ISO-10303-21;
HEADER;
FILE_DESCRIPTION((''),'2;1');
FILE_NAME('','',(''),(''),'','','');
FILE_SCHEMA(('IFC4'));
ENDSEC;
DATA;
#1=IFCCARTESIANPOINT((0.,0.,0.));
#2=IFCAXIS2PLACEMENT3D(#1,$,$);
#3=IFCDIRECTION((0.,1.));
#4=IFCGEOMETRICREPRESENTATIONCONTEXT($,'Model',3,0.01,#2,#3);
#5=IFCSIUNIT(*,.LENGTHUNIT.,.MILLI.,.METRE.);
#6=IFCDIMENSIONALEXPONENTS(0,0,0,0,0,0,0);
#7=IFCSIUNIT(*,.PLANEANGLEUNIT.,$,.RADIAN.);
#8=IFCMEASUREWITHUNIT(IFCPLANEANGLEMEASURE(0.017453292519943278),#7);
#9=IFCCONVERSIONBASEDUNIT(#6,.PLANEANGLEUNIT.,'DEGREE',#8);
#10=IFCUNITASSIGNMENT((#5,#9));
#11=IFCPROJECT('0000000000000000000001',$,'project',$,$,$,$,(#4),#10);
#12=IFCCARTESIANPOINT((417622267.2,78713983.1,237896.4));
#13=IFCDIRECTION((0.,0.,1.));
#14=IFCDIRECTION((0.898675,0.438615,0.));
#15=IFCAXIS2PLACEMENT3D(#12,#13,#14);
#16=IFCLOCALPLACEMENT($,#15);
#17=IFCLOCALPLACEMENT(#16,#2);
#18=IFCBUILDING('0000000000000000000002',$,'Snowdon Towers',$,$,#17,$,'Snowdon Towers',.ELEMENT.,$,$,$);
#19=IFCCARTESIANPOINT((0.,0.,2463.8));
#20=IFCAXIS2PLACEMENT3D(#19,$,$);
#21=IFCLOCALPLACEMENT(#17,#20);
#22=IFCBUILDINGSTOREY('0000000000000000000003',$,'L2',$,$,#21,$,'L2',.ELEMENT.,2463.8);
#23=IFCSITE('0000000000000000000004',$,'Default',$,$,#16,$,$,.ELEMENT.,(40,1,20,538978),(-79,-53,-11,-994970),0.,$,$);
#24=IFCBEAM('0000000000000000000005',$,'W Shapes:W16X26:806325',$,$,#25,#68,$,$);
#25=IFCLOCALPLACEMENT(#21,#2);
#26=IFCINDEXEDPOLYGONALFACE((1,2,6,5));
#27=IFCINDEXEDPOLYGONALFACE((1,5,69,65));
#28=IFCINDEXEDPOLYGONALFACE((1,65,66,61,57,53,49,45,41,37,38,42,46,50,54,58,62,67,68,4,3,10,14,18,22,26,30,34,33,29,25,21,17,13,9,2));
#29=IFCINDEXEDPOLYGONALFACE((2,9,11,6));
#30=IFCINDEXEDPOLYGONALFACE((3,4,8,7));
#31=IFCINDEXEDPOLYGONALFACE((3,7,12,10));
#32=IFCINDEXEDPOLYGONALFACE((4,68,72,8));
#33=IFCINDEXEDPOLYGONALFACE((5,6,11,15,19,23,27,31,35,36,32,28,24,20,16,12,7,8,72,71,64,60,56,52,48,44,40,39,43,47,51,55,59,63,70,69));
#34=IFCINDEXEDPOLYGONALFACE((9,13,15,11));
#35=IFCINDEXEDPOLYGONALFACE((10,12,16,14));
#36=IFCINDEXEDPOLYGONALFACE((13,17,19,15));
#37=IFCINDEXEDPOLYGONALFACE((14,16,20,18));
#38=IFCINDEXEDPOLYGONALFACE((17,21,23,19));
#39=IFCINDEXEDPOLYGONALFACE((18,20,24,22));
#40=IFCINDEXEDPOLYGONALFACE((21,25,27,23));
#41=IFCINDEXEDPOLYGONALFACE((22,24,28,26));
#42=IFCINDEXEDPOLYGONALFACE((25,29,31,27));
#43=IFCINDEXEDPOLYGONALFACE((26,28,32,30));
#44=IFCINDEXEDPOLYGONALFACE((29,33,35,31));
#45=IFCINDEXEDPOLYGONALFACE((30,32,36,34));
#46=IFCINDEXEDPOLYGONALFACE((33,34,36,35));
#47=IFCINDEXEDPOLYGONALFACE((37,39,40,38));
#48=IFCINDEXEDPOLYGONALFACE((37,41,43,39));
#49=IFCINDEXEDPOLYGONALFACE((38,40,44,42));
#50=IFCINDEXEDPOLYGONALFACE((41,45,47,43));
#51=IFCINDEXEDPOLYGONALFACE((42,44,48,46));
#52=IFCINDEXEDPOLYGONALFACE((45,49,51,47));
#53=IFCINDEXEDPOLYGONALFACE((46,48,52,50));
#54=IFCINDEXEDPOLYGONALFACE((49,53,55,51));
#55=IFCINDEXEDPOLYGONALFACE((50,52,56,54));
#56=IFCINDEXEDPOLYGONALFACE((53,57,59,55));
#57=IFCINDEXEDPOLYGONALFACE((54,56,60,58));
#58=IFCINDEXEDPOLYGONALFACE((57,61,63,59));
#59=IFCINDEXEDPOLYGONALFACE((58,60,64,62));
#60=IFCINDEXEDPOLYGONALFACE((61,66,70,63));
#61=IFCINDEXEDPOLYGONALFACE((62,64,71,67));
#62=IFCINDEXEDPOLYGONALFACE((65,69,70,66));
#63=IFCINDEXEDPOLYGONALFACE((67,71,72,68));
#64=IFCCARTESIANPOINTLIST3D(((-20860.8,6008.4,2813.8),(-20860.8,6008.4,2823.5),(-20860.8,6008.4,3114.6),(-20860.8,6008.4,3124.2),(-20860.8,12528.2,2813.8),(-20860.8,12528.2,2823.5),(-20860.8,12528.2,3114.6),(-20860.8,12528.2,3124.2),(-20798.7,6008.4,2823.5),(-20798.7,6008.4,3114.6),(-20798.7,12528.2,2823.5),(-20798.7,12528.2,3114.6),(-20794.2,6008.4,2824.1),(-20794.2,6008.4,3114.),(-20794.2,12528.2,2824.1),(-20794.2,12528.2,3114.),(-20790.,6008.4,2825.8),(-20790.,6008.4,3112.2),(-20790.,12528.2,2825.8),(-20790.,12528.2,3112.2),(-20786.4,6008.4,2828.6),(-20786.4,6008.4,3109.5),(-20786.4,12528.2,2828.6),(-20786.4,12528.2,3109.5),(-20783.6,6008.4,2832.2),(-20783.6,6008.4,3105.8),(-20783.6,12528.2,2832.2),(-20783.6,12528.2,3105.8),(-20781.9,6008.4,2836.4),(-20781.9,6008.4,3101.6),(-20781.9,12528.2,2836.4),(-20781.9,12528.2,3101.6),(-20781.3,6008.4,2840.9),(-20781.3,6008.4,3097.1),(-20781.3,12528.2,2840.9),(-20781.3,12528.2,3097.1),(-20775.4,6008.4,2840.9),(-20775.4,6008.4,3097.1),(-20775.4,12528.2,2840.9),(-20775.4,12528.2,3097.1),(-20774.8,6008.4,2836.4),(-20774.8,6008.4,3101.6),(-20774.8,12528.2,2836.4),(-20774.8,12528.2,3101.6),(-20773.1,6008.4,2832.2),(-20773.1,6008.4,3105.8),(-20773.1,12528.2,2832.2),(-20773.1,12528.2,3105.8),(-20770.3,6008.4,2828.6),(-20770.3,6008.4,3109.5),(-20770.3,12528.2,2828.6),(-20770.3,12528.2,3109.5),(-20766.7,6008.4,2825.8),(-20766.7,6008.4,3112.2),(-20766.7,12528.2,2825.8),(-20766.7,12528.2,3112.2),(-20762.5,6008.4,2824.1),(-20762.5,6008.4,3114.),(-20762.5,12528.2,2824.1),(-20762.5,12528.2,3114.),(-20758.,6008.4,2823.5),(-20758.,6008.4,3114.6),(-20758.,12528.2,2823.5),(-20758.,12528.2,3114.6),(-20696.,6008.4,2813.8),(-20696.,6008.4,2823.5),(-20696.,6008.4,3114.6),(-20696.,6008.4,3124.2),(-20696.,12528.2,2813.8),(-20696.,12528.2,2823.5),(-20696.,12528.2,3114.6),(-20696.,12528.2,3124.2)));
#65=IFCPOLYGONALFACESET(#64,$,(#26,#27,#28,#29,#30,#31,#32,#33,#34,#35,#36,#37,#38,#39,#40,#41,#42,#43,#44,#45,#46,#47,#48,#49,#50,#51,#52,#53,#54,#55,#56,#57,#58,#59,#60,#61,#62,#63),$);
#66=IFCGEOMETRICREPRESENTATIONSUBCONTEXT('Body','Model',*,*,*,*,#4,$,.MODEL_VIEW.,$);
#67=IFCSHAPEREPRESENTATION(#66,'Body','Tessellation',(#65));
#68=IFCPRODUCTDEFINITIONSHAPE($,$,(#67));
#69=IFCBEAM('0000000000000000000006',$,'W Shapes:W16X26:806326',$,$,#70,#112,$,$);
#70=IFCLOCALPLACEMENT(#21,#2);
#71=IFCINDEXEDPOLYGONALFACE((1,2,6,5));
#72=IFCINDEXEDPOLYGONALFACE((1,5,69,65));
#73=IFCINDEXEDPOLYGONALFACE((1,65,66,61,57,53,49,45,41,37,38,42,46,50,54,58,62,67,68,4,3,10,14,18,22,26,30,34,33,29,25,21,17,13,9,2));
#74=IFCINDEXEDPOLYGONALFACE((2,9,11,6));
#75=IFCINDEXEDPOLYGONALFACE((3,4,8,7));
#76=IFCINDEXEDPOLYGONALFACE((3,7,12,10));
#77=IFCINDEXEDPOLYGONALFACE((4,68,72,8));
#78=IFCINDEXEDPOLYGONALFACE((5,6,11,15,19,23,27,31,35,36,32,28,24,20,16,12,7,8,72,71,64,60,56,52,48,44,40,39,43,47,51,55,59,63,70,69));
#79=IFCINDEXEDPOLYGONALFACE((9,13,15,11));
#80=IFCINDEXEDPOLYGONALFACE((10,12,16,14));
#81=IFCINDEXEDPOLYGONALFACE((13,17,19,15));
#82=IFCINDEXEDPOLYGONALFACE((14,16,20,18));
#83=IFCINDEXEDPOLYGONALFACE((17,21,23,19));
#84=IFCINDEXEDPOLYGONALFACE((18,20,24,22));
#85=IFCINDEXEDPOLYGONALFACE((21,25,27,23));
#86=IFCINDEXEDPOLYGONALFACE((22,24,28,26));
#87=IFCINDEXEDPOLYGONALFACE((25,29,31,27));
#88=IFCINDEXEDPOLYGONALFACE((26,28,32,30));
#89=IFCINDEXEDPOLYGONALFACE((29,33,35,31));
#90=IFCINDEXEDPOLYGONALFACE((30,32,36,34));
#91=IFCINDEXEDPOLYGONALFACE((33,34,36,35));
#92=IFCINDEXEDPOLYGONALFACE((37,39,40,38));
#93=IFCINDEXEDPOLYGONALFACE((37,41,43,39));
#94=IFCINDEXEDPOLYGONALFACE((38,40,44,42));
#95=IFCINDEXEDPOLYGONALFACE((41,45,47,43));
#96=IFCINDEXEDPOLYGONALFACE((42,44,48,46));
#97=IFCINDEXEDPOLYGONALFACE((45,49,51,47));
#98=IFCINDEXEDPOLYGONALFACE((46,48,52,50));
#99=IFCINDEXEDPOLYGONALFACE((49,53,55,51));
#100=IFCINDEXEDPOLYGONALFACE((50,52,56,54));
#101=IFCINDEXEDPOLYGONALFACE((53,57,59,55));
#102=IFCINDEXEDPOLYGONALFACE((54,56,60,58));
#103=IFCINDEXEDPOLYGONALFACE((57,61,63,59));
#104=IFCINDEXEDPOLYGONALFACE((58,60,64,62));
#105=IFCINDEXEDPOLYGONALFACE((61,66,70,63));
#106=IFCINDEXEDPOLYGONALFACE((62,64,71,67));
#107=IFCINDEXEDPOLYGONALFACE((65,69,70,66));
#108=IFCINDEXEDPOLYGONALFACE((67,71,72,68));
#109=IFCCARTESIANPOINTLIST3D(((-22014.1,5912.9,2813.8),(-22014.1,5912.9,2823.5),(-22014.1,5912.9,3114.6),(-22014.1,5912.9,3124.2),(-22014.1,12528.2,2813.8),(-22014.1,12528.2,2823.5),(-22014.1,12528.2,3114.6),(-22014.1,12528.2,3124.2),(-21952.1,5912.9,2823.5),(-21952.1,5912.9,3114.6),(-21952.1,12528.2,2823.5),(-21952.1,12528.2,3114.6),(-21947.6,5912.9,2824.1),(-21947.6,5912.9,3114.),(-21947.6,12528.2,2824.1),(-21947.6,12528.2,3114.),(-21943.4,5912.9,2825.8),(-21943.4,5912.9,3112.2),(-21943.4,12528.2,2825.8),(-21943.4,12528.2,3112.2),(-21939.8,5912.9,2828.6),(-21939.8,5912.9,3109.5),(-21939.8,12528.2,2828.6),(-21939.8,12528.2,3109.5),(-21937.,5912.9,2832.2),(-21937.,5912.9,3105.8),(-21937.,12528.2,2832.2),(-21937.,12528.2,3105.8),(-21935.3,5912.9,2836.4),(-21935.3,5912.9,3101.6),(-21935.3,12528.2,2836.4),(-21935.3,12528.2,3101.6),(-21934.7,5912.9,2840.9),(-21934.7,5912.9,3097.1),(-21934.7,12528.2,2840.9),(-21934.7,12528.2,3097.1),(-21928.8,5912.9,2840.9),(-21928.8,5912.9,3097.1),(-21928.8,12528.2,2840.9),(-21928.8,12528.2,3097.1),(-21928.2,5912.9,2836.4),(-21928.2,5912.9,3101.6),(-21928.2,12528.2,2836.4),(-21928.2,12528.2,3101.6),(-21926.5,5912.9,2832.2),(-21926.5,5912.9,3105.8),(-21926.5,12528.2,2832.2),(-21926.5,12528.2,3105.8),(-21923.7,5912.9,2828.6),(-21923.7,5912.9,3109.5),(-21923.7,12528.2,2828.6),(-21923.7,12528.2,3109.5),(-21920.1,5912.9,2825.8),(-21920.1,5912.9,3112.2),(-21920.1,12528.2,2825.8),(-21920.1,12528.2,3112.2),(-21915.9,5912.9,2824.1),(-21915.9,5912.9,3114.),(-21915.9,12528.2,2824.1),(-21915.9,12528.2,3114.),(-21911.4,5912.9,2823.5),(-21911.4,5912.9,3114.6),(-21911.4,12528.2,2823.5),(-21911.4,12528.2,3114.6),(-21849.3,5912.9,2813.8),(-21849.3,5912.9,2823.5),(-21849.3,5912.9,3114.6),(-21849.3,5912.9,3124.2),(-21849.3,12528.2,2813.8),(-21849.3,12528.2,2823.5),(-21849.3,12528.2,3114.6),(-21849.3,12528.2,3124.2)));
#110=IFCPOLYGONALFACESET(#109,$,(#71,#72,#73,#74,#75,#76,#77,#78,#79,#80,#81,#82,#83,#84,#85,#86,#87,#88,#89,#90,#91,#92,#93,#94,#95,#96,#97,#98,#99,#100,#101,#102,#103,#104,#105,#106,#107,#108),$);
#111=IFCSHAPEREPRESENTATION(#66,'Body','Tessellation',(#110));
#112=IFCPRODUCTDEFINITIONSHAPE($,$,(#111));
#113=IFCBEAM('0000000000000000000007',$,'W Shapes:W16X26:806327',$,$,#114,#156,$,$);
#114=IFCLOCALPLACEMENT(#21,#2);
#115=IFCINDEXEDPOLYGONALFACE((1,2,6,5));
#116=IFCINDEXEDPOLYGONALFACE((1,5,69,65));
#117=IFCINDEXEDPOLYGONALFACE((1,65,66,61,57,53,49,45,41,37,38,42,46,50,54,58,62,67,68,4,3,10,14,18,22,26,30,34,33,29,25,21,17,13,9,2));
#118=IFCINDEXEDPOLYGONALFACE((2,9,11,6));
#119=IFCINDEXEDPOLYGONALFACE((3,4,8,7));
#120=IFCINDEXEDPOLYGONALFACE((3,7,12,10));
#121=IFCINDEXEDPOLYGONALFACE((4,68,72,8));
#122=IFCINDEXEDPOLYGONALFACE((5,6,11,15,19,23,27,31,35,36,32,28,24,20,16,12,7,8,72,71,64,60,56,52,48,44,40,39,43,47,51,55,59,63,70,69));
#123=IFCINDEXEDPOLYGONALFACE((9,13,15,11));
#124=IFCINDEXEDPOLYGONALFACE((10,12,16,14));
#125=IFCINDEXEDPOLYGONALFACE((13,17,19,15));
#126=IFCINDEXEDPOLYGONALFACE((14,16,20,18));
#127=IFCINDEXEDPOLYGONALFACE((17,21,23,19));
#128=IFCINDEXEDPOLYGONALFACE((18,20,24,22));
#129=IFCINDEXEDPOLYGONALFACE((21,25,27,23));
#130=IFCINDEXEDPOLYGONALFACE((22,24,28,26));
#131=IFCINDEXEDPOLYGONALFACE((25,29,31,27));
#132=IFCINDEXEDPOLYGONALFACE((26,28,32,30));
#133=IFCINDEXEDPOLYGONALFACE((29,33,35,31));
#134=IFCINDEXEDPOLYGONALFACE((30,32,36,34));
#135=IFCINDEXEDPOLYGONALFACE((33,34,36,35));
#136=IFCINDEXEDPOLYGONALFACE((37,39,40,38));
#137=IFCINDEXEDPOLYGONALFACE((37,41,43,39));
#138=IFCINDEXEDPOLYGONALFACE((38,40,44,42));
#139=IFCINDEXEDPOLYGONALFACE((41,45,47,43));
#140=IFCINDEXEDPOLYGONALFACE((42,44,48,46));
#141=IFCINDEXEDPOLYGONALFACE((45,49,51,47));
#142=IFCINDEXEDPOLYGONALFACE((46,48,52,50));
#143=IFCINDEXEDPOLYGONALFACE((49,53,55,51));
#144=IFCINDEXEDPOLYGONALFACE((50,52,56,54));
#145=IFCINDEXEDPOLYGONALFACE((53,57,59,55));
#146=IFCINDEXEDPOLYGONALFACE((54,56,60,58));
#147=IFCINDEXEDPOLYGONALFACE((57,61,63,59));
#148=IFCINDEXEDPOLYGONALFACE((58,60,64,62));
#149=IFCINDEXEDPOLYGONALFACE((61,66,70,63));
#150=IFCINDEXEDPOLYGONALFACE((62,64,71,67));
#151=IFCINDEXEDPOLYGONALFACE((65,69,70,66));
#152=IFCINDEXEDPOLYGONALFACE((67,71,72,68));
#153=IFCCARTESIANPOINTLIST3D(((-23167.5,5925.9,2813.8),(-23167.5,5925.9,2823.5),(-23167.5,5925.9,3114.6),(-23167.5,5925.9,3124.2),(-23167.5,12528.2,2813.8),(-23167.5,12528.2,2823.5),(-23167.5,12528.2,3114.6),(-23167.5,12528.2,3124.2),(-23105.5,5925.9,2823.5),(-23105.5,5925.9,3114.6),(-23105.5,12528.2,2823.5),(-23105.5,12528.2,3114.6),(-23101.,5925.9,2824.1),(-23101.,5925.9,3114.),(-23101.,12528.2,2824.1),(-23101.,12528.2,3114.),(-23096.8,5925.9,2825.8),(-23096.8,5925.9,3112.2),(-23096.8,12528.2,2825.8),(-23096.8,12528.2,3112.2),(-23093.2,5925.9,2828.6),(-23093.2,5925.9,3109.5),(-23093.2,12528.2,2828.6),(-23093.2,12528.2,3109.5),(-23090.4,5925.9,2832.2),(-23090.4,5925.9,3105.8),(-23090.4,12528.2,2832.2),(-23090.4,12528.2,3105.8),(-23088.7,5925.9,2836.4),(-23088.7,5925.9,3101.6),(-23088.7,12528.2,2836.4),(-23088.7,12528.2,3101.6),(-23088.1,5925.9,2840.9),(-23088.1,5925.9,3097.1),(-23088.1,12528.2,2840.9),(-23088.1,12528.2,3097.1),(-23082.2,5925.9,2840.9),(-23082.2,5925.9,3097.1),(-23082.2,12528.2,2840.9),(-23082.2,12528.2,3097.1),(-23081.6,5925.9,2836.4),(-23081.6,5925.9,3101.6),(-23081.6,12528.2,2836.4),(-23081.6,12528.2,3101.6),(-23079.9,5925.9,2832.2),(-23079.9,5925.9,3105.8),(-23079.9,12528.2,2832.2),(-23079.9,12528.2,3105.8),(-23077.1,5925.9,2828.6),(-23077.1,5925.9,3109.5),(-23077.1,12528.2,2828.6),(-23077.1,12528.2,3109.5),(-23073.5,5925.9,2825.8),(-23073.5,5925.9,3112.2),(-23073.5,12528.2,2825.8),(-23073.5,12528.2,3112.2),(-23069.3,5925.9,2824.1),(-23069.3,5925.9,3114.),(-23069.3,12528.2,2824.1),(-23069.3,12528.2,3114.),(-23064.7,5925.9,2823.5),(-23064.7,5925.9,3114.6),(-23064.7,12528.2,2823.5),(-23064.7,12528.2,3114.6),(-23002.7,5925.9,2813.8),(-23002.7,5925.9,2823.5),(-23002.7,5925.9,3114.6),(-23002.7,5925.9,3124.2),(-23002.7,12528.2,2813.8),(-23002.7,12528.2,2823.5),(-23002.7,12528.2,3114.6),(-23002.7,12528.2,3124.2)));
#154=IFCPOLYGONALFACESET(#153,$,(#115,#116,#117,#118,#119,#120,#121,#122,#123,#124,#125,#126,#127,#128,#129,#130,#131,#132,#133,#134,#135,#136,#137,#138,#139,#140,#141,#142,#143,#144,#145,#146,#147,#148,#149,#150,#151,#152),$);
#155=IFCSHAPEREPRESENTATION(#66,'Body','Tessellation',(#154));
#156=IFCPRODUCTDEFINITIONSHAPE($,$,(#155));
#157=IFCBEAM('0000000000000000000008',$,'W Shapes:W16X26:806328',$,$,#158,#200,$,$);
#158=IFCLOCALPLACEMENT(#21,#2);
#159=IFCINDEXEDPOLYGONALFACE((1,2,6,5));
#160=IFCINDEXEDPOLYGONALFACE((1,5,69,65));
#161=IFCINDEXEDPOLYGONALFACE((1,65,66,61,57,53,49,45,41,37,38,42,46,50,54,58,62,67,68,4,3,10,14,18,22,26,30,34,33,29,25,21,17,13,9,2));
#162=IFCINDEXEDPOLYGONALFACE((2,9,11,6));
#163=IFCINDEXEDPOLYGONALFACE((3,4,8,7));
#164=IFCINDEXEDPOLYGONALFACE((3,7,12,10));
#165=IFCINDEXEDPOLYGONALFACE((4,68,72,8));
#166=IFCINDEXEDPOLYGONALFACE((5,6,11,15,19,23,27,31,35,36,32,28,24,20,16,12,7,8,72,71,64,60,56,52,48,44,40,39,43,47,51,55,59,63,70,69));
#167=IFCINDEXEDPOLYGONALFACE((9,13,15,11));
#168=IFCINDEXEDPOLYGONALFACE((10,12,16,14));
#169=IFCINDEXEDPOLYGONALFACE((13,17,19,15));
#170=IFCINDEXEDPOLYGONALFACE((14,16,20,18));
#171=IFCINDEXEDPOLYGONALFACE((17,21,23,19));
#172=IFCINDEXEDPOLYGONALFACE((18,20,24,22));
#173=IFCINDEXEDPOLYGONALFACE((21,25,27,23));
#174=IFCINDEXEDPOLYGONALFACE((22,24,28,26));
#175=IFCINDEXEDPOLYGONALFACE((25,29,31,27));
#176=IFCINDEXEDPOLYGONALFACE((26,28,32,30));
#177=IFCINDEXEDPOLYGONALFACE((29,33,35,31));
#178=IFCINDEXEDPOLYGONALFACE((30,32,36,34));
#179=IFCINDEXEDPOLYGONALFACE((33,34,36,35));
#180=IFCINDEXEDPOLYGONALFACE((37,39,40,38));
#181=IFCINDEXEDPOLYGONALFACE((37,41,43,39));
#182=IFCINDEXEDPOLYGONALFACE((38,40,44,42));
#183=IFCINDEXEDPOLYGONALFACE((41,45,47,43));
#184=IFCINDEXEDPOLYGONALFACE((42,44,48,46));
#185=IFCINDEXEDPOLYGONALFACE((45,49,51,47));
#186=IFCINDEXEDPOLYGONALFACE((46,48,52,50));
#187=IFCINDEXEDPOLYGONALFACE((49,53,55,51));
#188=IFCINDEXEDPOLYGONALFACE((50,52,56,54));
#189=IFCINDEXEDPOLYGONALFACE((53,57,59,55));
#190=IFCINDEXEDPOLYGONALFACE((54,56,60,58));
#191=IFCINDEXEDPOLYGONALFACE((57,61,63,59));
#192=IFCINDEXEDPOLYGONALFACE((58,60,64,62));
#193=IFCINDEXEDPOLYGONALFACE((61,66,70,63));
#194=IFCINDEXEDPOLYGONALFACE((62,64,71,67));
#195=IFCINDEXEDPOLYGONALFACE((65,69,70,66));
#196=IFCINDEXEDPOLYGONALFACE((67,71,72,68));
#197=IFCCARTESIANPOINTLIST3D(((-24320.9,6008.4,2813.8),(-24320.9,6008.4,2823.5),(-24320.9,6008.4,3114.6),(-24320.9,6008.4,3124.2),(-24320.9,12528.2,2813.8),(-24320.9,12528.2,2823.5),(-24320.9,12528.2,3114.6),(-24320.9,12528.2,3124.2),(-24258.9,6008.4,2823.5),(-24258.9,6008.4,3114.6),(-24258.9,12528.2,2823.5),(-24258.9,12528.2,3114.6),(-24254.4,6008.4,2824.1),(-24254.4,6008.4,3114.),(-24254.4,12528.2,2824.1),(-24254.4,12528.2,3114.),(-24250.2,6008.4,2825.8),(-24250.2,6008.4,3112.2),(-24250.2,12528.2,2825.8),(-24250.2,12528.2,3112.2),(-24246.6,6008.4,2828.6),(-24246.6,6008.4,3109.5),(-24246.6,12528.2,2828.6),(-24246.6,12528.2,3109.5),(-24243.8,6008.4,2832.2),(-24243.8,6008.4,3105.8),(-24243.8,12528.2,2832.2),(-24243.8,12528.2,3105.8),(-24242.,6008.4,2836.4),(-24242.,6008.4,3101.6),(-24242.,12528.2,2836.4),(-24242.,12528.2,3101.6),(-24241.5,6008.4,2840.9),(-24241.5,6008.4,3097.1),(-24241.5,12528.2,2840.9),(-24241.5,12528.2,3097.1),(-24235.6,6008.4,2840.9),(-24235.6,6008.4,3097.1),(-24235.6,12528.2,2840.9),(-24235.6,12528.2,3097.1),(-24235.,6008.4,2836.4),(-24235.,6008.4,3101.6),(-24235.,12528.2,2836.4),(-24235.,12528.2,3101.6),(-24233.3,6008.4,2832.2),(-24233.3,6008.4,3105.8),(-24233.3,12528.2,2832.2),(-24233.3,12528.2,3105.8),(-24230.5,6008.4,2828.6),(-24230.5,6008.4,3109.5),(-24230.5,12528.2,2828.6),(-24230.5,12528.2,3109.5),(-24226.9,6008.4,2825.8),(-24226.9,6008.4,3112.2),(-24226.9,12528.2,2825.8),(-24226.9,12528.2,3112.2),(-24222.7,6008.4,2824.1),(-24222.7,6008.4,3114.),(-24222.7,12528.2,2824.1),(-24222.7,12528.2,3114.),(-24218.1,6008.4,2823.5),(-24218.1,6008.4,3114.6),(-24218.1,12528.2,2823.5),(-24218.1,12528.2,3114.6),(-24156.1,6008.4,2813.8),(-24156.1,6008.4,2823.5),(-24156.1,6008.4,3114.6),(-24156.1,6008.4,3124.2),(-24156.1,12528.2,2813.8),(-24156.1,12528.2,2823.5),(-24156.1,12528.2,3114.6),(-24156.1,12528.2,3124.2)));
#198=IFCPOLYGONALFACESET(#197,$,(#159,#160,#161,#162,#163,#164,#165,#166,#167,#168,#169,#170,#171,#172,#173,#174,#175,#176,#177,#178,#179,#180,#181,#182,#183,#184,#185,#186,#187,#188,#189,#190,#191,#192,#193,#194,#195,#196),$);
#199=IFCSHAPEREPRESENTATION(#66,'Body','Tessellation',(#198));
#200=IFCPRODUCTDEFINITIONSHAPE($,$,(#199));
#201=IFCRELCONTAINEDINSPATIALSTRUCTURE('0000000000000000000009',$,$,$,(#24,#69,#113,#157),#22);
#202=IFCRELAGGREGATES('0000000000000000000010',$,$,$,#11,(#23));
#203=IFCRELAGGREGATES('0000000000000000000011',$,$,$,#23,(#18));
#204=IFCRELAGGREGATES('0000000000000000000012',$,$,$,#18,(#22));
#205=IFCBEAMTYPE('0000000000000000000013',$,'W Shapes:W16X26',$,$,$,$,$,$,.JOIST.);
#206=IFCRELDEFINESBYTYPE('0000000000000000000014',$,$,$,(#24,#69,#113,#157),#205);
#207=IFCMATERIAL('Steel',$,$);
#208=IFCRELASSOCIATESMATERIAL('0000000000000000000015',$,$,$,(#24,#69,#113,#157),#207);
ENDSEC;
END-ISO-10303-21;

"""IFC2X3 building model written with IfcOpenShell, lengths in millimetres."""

from ifc_helpers import new_model, entity, si_unit, converted_unit, direction, frame, frame_2d, origin, place, context, subcontext, project, spatial, i_section, extrude, material, type_object, element, save


model = new_model("IFC2X3")

# Units and contexts
model_context = context("Model", 3, precision=0.01, world=origin(), true_north=direction((0.0, 1.0)))
body_context = subcontext(model_context, "Body", "Model", "MODEL_VIEW")
ifc_project = project(units=[si_unit("LENGTHUNIT", "METRE", prefix="MILLI"), converted_unit("PLANEANGLEUNIT", "DEGREE", entity("IfcPlaneAngleMeasure", 0.017453292519943278), si_unit("PLANEANGLEUNIT", "RADIAN"), dimensions=[0, 0, 0, 0, 0, 0, 0])], contexts=[model_context])

# Site, building, storey
site_placement = place(None, frame((417622267.2, 78713983.1, 237896.4), z_axis=(0.0, 0.0, 1.0), x_axis=(0.898675, 0.438615, 0.0)))
site = spatial("IfcSite", under=ifc_project, at=site_placement, Name="Default", CompositionType="ELEMENT", RefLatitude=(40, 1, 20, 538978), RefLongitude=(-79, -53, -11, -994970), RefElevation=0.0)
building_placement = place(site_placement, origin())
building = spatial("IfcBuilding", under=site, at=building_placement, Name="Snowdon Towers", LongName="Snowdon Towers", CompositionType="ELEMENT")
storey_placement = place(building_placement, frame((0.0, 0.0, 2463.8)))
storey = spatial("IfcBuildingStorey", under=building, at=storey_placement, Name="L2", LongName="L2", CompositionType="ELEMENT", Elevation=2463.8)

# Beams
ifc_material_1 = material(Name="Steel")
beam_type_1 = type_object("IfcBeamType", Name="W Shapes:W16X26", PredefinedType="JOIST")
beam_1_placement = place(storey_placement, frame((-20778.4, 12636.5, 3124.2), z_axis=(0.0, 0.0, 1.0), x_axis=(0.0, -1.0, 0.0)))
element("IfcBeam", 1, at=beam_1_placement, inside=storey, type_object=beam_type_1, material=ifc_material_1, Name="W Shapes:W16X26:806325", context=body_context, shape_type="SweptSolid", body=[
    extrude(i_section(OverallWidth=164.8, OverallDepth=310.4, WebThickness=5.9, FlangeThickness=9.6, FilletRadius=17.5, at=frame_2d((0.0, 0.0), x_axis=(0.0, 1.0))), frame((108.3, 0.0, -155.2), z_axis=(1.0, 0.0, 0.0), x_axis=(0.0, 0.0, -1.0)), (0.0, 0.0, 1.0), 6519.8),
])
beam_2_placement = place(storey_placement, frame((-21931.7, 12636.5, 3124.2), z_axis=(0.0, 0.0, 1.0), x_axis=(0.0, -1.0, 0.0)))
element("IfcBeam", 2, at=beam_2_placement, inside=storey, type_object=beam_type_1, material=ifc_material_1, Name="W Shapes:W16X26:806326", context=body_context, shape_type="SweptSolid", body=[
    extrude(i_section(OverallWidth=164.8, OverallDepth=310.4, WebThickness=5.9, FlangeThickness=9.6, FilletRadius=17.5, at=frame_2d((0.0, 0.0), x_axis=(0.0, 1.0))), frame((108.3, 0.0, -155.2), z_axis=(1.0, 0.0, 0.0), x_axis=(0.0, 0.0, -1.0)), (0.0, 0.0, 1.0), 6615.2),
])
beam_3_placement = place(storey_placement, frame((-23085.1, 12636.5, 3124.2), z_axis=(0.0, 0.0, 1.0), x_axis=(0.0, -1.0, 0.0)))
element("IfcBeam", 3, at=beam_3_placement, inside=storey, type_object=beam_type_1, material=ifc_material_1, Name="W Shapes:W16X26:806327", context=body_context, shape_type="SweptSolid", body=[
    extrude(i_section(OverallWidth=164.8, OverallDepth=310.4, WebThickness=5.9, FlangeThickness=9.6, FilletRadius=17.5, at=frame_2d((0.0, 0.0), x_axis=(0.0, 1.0))), frame((108.3, 0.0, -155.2), z_axis=(1.0, 0.0, 0.0), x_axis=(0.0, 0.0, -1.0)), (0.0, 0.0, 1.0), 6602.3),
])
beam_4_placement = place(storey_placement, frame((-24238.5, 12636.5, 3124.2), z_axis=(0.0, 0.0, 1.0), x_axis=(0.0, -1.0, 0.0)))
element("IfcBeam", 4, at=beam_4_placement, inside=storey, type_object=beam_type_1, material=ifc_material_1, Name="W Shapes:W16X26:806328", context=body_context, shape_type="SweptSolid", body=[
    extrude(i_section(OverallWidth=164.8, OverallDepth=310.4, WebThickness=5.9, FlangeThickness=9.6, FilletRadius=17.5, at=frame_2d((0.0, 0.0), x_axis=(0.0, 1.0))), frame((108.3, 0.0, -155.2), z_axis=(1.0, 0.0, 0.0), x_axis=(0.0, 0.0, -1.0)), (0.0, 0.0, 1.0), 6519.8),
])

save(model, "model.ifc")
